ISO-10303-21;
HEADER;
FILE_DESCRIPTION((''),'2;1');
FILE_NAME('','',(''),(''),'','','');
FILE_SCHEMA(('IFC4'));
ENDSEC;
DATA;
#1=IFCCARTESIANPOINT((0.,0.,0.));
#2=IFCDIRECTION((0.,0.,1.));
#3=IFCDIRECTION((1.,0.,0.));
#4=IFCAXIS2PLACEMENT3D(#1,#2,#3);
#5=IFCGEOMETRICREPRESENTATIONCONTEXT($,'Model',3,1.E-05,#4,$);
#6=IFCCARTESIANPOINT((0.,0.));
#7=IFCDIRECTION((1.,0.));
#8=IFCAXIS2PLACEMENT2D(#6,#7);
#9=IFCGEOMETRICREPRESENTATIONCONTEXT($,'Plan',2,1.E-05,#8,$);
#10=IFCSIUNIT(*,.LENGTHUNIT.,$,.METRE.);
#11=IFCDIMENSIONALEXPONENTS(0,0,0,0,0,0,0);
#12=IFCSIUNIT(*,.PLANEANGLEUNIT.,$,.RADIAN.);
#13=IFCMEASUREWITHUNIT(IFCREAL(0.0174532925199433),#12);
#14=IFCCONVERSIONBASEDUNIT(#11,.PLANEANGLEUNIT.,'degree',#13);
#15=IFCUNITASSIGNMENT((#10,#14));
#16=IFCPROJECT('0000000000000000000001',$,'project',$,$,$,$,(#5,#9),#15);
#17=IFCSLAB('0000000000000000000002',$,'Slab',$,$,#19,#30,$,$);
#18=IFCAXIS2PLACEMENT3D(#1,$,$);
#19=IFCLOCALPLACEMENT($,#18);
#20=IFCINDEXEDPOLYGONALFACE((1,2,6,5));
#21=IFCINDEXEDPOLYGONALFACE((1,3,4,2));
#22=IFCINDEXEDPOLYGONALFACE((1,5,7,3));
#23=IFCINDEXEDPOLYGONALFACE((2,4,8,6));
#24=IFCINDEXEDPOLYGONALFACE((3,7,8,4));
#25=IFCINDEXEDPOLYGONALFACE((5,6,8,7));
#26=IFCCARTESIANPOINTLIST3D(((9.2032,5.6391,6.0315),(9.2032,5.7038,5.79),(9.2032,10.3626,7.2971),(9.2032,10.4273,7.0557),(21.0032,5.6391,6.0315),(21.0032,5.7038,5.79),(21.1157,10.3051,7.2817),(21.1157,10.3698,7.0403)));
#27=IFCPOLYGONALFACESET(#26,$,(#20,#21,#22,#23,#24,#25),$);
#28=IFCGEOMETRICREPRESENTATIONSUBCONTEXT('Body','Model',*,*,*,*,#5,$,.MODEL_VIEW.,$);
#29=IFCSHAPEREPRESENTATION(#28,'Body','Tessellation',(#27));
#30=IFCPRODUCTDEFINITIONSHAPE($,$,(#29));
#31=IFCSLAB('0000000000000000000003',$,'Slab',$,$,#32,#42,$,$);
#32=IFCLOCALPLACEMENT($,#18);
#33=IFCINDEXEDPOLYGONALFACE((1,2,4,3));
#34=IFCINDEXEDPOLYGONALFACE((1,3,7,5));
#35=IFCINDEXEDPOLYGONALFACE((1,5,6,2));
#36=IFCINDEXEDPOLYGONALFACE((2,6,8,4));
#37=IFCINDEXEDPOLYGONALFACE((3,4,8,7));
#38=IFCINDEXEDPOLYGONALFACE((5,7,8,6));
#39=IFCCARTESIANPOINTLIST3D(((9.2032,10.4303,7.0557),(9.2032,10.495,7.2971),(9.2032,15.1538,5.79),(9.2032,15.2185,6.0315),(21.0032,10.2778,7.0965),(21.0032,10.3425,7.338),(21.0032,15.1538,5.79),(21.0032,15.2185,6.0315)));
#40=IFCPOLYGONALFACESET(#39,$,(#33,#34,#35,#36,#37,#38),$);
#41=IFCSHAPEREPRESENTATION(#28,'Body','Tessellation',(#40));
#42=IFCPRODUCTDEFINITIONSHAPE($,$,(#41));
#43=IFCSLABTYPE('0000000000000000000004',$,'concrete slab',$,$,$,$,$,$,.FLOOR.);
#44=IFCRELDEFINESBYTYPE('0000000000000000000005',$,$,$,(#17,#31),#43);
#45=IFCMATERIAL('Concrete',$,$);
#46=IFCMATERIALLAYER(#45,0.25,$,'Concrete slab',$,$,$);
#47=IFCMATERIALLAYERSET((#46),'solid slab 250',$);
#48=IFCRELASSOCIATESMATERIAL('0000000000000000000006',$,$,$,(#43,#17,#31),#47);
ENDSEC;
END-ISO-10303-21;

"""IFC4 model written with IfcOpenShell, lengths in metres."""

from ifc_helpers import new_model, entity, si_unit, converted_unit, frame, origin_with_axes, origin_2d_with_axis, place, context, subcontext, project, line, indexed_curve, outline, extrude, material, layer, layer_set, layer_usage, type_object, element, save


model = new_model("IFC4")

# Units and contexts
model_context = context("Model", 3, precision=1e-05, world=origin_with_axes())
plan_context = context("Plan", 2, precision=1e-05, world=origin_2d_with_axis())
body_context = subcontext(model_context, "Body", "Model", "MODEL_VIEW")
ifc_project = project(units=[si_unit("LENGTHUNIT", "METRE"), converted_unit("PLANEANGLEUNIT", "degree", entity("IfcReal", 0.0174532925199433), si_unit("PLANEANGLEUNIT", "RADIAN"), dimensions=[0, 0, 0, 0, 0, 0, 0])], contexts=[model_context, plan_context])

# Slabs
ifc_material = material(Name="Concrete")
ifc_layer = layer(ifc_material, 0.25, Name="Concrete slab")
ifc_layer_set = layer_set([ifc_layer], Name="solid slab 250")
ifc_layer_usage_1 = layer_usage(ifc_layer_set, "AXIS3", "POSITIVE", 0.0)
slab_type = type_object("IfcSlabType", Name="concrete slab", PredefinedType="FLOOR", material=ifc_layer_set)
slab_1_placement = place(None, frame((9.2032, 5.7038, 5.79), z_axis=(0.0, -0.258819, 0.965926), x_axis=(1.0, 0.0, 0.0)))
element("IfcSlab", 1, at=slab_1_placement, type_object=slab_type, material=ifc_layer_usage_1, Name="Slab", context=body_context, shape_type="SweptSolid", body=[
    extrude(outline(indexed_curve([(0.0, 0.0), (11.8, 0.0), (11.9125, 4.8306), (0.0, 4.8901)], segments=[line(4, 1), line(1, 2), line(2, 3), line(3, 4)], self_intersect=False)), None, (0.0, 0.0, 1.0), 0.25),
])
ifc_layer_usage_2 = layer_usage(ifc_layer_set, "AXIS3", "POSITIVE", 0.0)
slab_2_placement = place(None, frame((21.0032, 15.1538, 5.79), z_axis=(0.0, 0.258819, 0.965926), x_axis=(-1.0, 0.0, 0.0)))
element("IfcSlab", 2, at=slab_2_placement, type_object=slab_type, material=ifc_layer_usage_2, Name="Slab", context=body_context, shape_type="SweptSolid", body=[
    extrude(outline(indexed_curve([(0.0, 0.0), (11.8, 0.0), (11.8, 4.8901), (0.0, 5.048)], segments=[line(4, 1), line(1, 2), line(2, 3), line(3, 4)], self_intersect=False)), None, (0.0, 0.0, 1.0), 0.25),
])

save(model, "model.ifc")
